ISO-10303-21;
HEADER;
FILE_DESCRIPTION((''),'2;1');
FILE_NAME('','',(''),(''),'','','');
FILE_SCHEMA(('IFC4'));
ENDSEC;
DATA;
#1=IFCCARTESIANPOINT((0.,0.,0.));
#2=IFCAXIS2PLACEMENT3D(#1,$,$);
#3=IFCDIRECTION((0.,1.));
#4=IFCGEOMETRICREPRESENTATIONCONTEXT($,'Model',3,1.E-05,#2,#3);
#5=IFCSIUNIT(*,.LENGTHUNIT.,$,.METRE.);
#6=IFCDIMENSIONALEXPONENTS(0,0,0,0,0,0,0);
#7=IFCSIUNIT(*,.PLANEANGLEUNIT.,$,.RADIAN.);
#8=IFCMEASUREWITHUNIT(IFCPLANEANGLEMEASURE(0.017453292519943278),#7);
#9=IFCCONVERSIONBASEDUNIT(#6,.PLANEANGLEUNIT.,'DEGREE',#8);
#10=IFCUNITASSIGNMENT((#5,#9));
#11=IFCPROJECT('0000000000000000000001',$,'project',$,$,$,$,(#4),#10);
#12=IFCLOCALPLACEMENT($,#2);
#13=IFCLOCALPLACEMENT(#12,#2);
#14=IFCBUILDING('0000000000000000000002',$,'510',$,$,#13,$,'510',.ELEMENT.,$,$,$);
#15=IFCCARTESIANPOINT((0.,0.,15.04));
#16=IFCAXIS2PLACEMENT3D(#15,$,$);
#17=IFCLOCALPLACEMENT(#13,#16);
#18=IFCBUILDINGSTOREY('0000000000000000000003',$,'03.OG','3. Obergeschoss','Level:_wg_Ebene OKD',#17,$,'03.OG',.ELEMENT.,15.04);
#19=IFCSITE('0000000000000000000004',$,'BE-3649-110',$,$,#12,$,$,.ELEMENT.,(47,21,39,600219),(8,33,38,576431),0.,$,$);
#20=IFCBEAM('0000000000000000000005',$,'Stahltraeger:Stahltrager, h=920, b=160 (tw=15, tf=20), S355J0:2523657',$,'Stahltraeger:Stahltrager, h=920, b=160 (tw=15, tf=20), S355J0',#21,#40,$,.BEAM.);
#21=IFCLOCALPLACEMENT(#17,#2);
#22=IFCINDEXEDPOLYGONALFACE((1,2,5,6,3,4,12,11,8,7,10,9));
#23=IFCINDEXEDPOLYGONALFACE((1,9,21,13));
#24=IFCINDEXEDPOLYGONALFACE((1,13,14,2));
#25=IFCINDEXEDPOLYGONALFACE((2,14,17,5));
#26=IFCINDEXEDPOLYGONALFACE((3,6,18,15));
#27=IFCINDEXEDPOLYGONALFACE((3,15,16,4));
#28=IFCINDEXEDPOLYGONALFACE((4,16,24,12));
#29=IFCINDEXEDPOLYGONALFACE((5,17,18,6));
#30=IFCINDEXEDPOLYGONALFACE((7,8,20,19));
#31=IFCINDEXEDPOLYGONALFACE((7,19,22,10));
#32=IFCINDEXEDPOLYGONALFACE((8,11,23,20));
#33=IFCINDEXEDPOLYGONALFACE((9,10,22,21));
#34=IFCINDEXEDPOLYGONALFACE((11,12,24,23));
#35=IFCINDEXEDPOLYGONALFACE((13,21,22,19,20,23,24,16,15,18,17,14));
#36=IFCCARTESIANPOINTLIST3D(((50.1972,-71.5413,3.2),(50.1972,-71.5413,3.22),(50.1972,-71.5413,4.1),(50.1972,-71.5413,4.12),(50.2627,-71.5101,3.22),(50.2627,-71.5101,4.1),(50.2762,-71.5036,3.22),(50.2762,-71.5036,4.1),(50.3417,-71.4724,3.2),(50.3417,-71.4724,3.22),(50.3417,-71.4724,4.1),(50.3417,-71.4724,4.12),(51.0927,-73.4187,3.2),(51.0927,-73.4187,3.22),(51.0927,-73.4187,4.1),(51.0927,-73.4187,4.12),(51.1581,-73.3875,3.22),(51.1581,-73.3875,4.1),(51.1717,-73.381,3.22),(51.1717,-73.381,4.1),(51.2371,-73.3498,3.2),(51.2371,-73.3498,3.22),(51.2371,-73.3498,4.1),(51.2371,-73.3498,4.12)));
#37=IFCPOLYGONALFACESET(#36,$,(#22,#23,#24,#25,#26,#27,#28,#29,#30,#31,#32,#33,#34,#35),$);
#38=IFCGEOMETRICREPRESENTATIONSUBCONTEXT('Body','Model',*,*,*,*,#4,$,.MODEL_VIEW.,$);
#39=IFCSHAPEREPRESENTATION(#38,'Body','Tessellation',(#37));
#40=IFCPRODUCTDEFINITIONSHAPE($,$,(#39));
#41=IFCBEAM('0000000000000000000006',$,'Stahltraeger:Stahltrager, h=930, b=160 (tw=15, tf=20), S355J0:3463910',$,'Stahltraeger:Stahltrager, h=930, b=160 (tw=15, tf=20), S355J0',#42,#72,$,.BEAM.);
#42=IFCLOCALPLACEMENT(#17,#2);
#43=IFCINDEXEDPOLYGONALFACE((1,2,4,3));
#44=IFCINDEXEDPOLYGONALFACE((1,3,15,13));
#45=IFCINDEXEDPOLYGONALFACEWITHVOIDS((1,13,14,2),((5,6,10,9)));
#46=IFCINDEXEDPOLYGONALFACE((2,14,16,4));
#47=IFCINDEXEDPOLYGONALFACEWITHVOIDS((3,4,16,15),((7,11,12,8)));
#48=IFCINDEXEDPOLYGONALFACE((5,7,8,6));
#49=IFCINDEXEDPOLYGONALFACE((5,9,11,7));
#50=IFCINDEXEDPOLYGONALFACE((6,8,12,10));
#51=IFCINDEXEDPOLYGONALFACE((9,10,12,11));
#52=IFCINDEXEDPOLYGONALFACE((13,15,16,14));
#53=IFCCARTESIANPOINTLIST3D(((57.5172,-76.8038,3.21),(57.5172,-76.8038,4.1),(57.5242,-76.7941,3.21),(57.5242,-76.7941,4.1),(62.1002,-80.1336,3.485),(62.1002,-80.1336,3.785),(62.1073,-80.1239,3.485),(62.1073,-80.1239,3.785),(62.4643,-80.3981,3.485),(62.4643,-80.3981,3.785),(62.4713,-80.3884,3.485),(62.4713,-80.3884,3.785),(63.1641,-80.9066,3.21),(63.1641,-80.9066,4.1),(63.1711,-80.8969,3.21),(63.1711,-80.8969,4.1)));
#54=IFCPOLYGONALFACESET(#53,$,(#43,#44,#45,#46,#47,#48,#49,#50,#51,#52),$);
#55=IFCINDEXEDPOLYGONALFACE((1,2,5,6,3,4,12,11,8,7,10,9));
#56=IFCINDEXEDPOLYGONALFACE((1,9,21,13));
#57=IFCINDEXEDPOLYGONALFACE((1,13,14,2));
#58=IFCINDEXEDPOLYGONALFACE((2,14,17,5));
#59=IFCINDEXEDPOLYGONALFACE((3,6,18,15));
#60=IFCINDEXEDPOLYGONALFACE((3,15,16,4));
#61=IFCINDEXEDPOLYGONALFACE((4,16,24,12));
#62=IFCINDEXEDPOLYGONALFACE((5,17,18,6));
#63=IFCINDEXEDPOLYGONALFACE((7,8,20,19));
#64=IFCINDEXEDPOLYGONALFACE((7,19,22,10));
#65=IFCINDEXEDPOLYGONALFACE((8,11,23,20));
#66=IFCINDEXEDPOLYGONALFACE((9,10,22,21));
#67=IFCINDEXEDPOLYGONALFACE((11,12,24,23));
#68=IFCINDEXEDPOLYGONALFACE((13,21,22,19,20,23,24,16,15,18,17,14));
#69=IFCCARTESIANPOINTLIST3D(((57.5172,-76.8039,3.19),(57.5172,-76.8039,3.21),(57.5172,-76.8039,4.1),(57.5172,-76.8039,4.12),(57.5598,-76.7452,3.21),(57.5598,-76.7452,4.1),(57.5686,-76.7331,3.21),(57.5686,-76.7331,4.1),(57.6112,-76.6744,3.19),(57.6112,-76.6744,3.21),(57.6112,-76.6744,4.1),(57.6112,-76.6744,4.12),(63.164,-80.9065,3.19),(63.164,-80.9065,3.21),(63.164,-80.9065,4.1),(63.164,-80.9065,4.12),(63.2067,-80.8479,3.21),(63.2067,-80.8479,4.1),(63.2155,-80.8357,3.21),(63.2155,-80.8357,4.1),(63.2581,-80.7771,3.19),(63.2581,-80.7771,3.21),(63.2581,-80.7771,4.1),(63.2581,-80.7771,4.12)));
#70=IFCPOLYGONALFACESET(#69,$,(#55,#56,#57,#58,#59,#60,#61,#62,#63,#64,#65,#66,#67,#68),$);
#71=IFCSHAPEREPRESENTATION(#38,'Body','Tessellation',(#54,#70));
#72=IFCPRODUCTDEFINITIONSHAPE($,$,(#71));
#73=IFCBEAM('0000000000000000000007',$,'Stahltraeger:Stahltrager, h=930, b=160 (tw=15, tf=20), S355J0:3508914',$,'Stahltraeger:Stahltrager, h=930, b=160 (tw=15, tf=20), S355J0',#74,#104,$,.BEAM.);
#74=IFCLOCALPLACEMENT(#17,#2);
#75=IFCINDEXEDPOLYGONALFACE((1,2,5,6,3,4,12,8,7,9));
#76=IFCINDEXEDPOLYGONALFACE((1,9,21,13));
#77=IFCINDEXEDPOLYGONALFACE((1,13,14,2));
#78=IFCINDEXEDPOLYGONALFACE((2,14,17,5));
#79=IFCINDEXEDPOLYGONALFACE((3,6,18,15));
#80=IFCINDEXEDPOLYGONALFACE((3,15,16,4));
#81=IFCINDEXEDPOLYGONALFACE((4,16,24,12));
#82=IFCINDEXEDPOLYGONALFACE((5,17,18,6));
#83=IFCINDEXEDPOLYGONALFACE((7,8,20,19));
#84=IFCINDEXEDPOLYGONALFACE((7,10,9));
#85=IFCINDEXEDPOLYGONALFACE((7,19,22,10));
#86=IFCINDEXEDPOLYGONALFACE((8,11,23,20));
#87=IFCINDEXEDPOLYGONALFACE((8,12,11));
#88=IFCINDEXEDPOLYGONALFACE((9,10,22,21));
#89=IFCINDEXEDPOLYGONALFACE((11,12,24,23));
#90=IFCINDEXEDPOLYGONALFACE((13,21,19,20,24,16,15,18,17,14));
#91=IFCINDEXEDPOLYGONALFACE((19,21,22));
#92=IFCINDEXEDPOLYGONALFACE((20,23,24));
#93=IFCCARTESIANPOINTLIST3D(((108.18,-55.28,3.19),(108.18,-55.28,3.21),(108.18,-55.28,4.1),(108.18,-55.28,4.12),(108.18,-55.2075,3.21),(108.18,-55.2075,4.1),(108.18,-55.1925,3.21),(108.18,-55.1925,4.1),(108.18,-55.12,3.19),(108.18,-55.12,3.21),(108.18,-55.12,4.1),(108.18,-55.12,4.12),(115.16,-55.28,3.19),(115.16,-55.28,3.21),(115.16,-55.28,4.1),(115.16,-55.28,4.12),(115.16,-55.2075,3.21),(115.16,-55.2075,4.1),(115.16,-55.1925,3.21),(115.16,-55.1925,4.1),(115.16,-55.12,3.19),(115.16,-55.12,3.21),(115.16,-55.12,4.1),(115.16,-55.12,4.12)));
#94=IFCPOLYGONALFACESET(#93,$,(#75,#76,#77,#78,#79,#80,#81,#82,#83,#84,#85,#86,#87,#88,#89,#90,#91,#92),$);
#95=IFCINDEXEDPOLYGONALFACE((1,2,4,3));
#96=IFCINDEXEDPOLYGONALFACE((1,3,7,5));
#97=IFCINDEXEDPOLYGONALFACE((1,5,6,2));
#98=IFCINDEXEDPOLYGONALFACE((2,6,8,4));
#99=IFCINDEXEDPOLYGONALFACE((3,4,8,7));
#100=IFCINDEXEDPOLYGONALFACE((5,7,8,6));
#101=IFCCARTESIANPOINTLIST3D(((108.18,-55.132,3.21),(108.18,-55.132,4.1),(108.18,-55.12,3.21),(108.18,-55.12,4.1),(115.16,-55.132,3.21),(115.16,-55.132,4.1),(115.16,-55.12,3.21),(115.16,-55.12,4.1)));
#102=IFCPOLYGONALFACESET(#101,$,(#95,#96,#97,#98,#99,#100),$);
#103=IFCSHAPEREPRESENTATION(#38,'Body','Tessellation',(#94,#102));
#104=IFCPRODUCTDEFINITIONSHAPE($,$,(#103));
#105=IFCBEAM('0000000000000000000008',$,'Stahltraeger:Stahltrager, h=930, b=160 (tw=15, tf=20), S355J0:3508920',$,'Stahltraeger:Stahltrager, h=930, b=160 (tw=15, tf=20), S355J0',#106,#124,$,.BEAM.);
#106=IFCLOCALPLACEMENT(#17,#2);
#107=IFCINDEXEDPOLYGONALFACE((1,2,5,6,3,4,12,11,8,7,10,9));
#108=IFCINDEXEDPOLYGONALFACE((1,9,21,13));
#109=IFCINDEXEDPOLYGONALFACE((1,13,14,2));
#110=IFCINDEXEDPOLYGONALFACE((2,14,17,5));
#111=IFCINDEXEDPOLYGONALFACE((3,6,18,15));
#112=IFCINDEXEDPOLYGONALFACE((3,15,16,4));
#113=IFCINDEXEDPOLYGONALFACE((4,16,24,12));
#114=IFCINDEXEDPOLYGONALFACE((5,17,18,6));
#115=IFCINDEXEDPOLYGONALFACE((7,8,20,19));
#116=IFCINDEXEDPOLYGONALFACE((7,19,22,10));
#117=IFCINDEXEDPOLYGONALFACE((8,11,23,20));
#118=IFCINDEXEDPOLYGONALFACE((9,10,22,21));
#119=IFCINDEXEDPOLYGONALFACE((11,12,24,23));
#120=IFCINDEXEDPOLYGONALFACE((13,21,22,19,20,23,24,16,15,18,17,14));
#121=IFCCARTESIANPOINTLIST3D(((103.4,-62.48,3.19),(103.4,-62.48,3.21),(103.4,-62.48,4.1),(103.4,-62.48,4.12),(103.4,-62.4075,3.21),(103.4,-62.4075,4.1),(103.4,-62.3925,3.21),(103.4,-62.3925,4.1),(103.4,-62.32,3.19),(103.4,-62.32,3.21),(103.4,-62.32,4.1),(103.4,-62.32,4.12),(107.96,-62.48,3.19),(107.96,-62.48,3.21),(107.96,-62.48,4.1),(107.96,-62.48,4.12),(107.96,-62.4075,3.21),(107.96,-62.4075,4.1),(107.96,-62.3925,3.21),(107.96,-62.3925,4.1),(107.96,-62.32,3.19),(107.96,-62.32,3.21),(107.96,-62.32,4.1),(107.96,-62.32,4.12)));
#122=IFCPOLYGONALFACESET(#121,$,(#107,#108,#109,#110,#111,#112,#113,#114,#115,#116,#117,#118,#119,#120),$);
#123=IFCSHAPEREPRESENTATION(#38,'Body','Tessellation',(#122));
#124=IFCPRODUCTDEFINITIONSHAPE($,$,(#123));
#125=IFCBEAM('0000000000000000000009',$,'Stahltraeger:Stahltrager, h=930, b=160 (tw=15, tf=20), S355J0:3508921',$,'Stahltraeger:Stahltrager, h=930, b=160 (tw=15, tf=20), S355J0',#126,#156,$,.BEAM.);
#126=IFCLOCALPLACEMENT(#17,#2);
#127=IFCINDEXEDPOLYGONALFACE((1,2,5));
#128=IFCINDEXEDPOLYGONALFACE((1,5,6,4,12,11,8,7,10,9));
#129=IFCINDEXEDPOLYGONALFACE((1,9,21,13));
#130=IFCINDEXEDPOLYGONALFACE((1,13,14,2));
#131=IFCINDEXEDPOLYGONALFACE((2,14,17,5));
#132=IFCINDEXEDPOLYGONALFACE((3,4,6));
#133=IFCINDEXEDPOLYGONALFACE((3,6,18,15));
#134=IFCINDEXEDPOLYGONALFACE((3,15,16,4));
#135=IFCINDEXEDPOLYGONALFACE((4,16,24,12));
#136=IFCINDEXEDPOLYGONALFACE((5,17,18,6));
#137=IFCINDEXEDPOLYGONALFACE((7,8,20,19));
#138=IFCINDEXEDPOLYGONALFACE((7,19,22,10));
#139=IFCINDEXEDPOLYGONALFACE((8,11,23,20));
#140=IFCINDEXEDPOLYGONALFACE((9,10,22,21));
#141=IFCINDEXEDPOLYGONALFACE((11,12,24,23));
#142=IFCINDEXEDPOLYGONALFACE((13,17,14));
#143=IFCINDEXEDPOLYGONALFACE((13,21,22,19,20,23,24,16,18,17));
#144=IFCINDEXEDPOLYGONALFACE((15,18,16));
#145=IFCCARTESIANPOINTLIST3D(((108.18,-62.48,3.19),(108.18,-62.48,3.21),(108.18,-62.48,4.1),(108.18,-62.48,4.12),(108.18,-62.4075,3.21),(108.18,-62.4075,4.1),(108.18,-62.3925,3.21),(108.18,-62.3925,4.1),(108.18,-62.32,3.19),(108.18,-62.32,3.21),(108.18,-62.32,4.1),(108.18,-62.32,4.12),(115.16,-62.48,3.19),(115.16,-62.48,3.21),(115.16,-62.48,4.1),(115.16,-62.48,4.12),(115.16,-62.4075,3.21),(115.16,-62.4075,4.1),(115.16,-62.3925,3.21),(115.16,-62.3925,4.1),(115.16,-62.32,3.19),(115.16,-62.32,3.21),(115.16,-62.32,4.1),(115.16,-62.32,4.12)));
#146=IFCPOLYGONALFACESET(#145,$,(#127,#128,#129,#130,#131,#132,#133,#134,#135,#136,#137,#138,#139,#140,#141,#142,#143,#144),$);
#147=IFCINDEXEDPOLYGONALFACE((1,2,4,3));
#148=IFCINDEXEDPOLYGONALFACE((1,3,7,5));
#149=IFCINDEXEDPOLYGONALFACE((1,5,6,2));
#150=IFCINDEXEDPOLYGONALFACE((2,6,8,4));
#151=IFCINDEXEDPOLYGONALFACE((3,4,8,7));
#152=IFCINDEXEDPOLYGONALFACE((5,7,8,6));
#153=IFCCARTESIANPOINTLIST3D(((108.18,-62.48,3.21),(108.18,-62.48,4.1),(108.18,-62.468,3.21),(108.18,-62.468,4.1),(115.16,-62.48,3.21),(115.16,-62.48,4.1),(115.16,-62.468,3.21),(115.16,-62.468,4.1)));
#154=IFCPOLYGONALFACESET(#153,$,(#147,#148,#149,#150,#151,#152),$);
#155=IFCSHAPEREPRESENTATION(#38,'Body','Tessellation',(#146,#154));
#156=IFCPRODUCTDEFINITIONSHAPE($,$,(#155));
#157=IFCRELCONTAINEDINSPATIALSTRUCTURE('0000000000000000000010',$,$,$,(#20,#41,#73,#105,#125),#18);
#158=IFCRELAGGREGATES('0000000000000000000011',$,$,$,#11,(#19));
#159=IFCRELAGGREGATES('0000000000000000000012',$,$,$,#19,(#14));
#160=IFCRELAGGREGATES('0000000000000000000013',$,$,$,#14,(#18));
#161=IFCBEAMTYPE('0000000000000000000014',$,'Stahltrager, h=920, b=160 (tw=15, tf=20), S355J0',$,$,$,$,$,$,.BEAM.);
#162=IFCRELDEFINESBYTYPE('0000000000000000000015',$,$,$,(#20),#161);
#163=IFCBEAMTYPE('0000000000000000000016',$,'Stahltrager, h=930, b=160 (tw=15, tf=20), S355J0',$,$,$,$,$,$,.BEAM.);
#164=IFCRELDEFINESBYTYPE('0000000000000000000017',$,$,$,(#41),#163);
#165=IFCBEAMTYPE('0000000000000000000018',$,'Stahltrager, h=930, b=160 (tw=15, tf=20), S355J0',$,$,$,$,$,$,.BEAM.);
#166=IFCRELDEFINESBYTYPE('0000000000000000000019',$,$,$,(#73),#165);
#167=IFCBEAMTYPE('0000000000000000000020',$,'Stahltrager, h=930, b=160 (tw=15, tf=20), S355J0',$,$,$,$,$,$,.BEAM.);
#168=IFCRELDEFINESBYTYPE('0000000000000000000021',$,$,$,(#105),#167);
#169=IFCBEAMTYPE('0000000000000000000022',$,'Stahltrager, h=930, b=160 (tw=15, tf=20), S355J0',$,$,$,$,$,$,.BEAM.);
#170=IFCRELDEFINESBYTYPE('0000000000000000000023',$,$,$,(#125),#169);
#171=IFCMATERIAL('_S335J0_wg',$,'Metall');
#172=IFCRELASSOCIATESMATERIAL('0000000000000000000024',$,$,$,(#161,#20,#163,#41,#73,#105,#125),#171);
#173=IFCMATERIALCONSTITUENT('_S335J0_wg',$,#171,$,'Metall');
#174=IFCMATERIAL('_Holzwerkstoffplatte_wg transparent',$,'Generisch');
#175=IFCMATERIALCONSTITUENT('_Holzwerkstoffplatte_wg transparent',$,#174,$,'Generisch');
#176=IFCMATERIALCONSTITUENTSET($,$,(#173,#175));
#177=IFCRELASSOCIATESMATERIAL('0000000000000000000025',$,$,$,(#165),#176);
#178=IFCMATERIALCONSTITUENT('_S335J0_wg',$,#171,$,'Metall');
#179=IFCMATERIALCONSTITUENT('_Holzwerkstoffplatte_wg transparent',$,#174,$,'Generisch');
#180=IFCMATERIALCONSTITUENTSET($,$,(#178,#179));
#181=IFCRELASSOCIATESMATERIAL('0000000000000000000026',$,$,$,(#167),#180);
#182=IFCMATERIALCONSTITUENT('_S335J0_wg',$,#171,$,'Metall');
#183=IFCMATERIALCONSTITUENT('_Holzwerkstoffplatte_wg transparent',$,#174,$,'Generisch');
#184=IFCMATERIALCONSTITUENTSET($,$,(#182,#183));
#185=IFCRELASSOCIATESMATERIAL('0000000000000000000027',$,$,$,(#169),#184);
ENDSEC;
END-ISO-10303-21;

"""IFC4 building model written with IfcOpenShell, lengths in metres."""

from ifc_helpers import new_model, entity, si_unit, converted_unit, direction, frame, origin, place, context, subcontext, project, spatial, indexed_curve, outline, extrude, source, transform, mapped, material, constituent, constituent_set, type_object, type_shapes, element, save


model = new_model("IFC4")

# Units and contexts
model_context = context("Model", 3, precision=1e-05, world=origin(), true_north=direction((0.0, 1.0)))
body_context = subcontext(model_context, "Body", "Model", "MODEL_VIEW")
ifc_project = project(units=[si_unit("LENGTHUNIT", "METRE"), converted_unit("PLANEANGLEUNIT", "DEGREE", entity("IfcPlaneAngleMeasure", 0.017453292519943278), si_unit("PLANEANGLEUNIT", "RADIAN"), dimensions=[0, 0, 0, 0, 0, 0, 0])], contexts=[model_context])

# Site, building, storey
site_placement = place(None, origin())
site = spatial("IfcSite", under=ifc_project, at=site_placement, Name="BE-3649-110", CompositionType="ELEMENT", RefLatitude=(47, 21, 39, 600219), RefLongitude=(8, 33, 38, 576431), RefElevation=0.0)
building_placement = place(site_placement, origin())
building = spatial("IfcBuilding", under=site, at=building_placement, Name="510", LongName="510", CompositionType="ELEMENT")
storey_placement = place(building_placement, frame((0.0, 0.0, 15.04)))
storey = spatial("IfcBuildingStorey", under=building, at=storey_placement, Name="03.OG", Description="3. Obergeschoss", ObjectType="Level:_wg_Ebene OKD", LongName="03.OG", CompositionType="ELEMENT", Elevation=15.04)

# Beams, openings
ifc_material_1 = material(Name="_S335J0_wg", Category="Metall")
beam_type_1 = type_object("IfcBeamType", Name="Stahltrager, h=920, b=160 (tw=15, tf=20), S355J0", PredefinedType="BEAM", material=ifc_material_1)
shared_shape_1 = source(origin(), body_context, "Body", "SweptSolid", [
    extrude(outline(indexed_curve([(-0.08, -0.44), (-0.08, -0.46), (0.08, -0.46), (0.08, -0.44), (0.0075, -0.44), (0.0075, 0.44), (0.08, 0.44), (0.08, 0.46), (-0.08, 0.46), (-0.08, 0.44), (-0.0075, 0.44), (-0.0075, -0.44), (-0.08, -0.44)], self_intersect=False)), frame((0.9677, 0.0344, 0.46), z_axis=(0.430511, -0.902585, 0.0), x_axis=(0.902585, 0.430511, 0.0)), (0.0, 0.0, -1.0), 2.08),
])
type_shapes(beam_type_1, [shared_shape_1])
beam_1_placement = place(storey_placement, frame((50.1972, -73.4187, 3.2)))
beam_1 = element("IfcBeam", 1, at=beam_1_placement, inside=storey, type_object=beam_type_1, material=ifc_material_1, Name="Stahltraeger:Stahltrager, h=920, b=160 (tw=15, tf=20), S355J0:2523657", ObjectType="Stahltraeger:Stahltrager, h=920, b=160 (tw=15, tf=20), S355J0", PredefinedType="BEAM", context=body_context, shape_type="MappedRepresentation", body=[
    mapped(shared_shape_1, transform((0.0, 0.0, 0.0), scale=1.0)),
])
opening_1_placement = place(storey_placement, frame((50.1972, -73.4187, 3.2)))
element("IfcOpeningElement", 2, at=opening_1_placement, cuts=beam_1, PredefinedType="OPENING", context=body_context, shape_type="SweptSolid", body=[
    extrude(outline(indexed_curve([(-0.32, -0.22), (0.32, -0.22), (0.32, 0.22), (-0.32, 0.22), (-0.32, -0.22)], self_intersect=False)), frame((0.5148, 0.9664, -14.6217), z_axis=(0.902585, 0.430511, 0.0), x_axis=(-0.430511, 0.902585, 0.0)), (0.0, 0.0, 1.0), 0.015),
])
beam_type_2 = type_object("IfcBeamType", Name="Stahltrager, h=930, b=160 (tw=15, tf=20), S355J0", PredefinedType="BEAM", material=ifc_material_1)
shared_shape_2 = source(origin(), body_context, "Body", "SweptSolid", [
    extrude(outline(indexed_curve([(-0.445, -3.49), (0.445, -3.49), (0.445, 3.49), (-0.445, 3.49), (-0.445, -3.49)], self_intersect=False), holes=[indexed_curve([(-0.13, -2.175), (0.17, -2.175), (0.17, -2.625), (-0.13, -2.625), (-0.13, -2.175)], self_intersect=False)]), frame((2.8235, 2.0514, 0.465), z_axis=(0.587785, 0.809017, 0.0), x_axis=(0.0, 0.0, -1.0)), (0.0, 0.0, 1.0), 0.012),
    extrude(outline(indexed_curve([(-0.08, -0.445), (-0.08, -0.465), (0.08, -0.465), (0.08, -0.445), (0.0075, -0.445), (0.0075, 0.445), (0.08, 0.445), (0.08, 0.465), (-0.08, 0.465), (-0.08, 0.445), (-0.0075, 0.445), (-0.0075, -0.445), (-0.08, -0.445)], self_intersect=False)), frame((0.0471, 4.1674, 0.465), z_axis=(-0.809017, 0.587785, 0.0), x_axis=(-0.587785, -0.809017, 0.0)), (0.0, 0.0, -1.0), 6.9799),
])
type_shapes(beam_type_2, [shared_shape_2])
beam_2_placement = place(storey_placement, frame((57.5172, -80.9066, 3.19)))
beam_2 = element("IfcBeam", 3, at=beam_2_placement, inside=storey, type_object=beam_type_2, material=ifc_material_1, Name="Stahltraeger:Stahltrager, h=930, b=160 (tw=15, tf=20), S355J0:3463910", ObjectType="Stahltraeger:Stahltrager, h=930, b=160 (tw=15, tf=20), S355J0", PredefinedType="BEAM", context=body_context, shape_type="MappedRepresentation", body=[
    mapped(shared_shape_2, transform((0.0, 0.0, 0.0), scale=1.0)),
])
opening_2_placement = place(storey_placement, frame((57.5172, -80.9066, 3.19)))
element("IfcOpeningElement", 4, at=opening_2_placement, cuts=beam_2, PredefinedType="OPENING", context=body_context, shape_type="SweptSolid", body=[
    extrude(outline(indexed_curve([(-0.225, -0.15), (0.225, -0.15), (0.225, 0.15), (-0.225, 0.15), (-0.225, -0.15)], self_intersect=False)), frame((4.8165, 0.7115, -14.595), z_axis=(-0.587785, -0.809017, 0.0), x_axis=(-0.809017, 0.587785, 0.0)), (0.0, 0.0, 1.0), 0.015),
])

# Beams
ifc_constituent_1 = constituent(ifc_material_1, Name="_S335J0_wg", Category="Metall")
ifc_material_2 = material(Name="_Holzwerkstoffplatte_wg transparent", Category="Generisch")
ifc_constituent_2 = constituent(ifc_material_2, Name="_Holzwerkstoffplatte_wg transparent", Category="Generisch")
ifc_constituent_set_1 = constituent_set(constituents=[ifc_constituent_1, ifc_constituent_2])
beam_type_3 = type_object("IfcBeamType", Name="Stahltrager, h=930, b=160 (tw=15, tf=20), S355J0", PredefinedType="BEAM", material=ifc_constituent_set_1)
shared_shape_3 = source(origin(), body_context, "Body", "SweptSolid", [
    extrude(outline(indexed_curve([(-0.465, -0.08), (-0.445, -0.08), (-0.445, -0.0075), (0.445, -0.0075), (0.445, -0.08), (0.465, -0.08), (0.465, 0.08), (0.445, 0.08), (0.445, 0.0075), (-0.445, 0.0075), (-0.445, 0.08), (-0.465, 0.08), (-0.465, -0.08)], self_intersect=False)), frame((-3.49, 0.0, 0.0), z_axis=(1.0, 0.0, 0.0), x_axis=(0.0, 0.0, -1.0)), (0.0, 0.0, 1.0), 6.98),
    extrude(outline(indexed_curve([(-0.445, -0.006), (0.445, -0.006), (0.445, 0.006), (-0.445, 0.006), (-0.445, -0.006)], self_intersect=False)), frame((-3.49, 0.074, 0.0), z_axis=(1.0, 0.0, 0.0), x_axis=(0.0, 0.0, -1.0)), (0.0, 0.0, 1.0), 6.98),
])
type_shapes(beam_type_3, [shared_shape_3])
beam_3_placement = place(storey_placement, frame((111.67, -55.2, 3.655)))
element("IfcBeam", 5, at=beam_3_placement, inside=storey, type_object=beam_type_3, material=ifc_material_1, Name="Stahltraeger:Stahltrager, h=930, b=160 (tw=15, tf=20), S355J0:3508914", ObjectType="Stahltraeger:Stahltrager, h=930, b=160 (tw=15, tf=20), S355J0", PredefinedType="BEAM", context=body_context, shape_type="MappedRepresentation", body=[
    mapped(shared_shape_3, transform((0.0, 0.0, 0.0), scale=1.0)),
])
ifc_constituent_3 = constituent(ifc_material_1, Name="_S335J0_wg", Category="Metall")
ifc_constituent_4 = constituent(ifc_material_2, Name="_Holzwerkstoffplatte_wg transparent", Category="Generisch")
ifc_constituent_set_2 = constituent_set(constituents=[ifc_constituent_3, ifc_constituent_4])
beam_type_4 = type_object("IfcBeamType", Name="Stahltrager, h=930, b=160 (tw=15, tf=20), S355J0", PredefinedType="BEAM", material=ifc_constituent_set_2)
shared_shape_4 = source(origin(), body_context, "Body", "SweptSolid", [
    extrude(outline(indexed_curve([(-0.465, -0.08), (-0.445, -0.08), (-0.445, -0.0075), (0.445, -0.0075), (0.445, -0.08), (0.465, -0.08), (0.465, 0.08), (0.445, 0.08), (0.445, 0.0075), (-0.445, 0.0075), (-0.445, 0.08), (-0.465, 0.08), (-0.465, -0.08)], self_intersect=False)), frame((-2.28, 0.0, 0.0), z_axis=(1.0, 0.0, 0.0), x_axis=(0.0, 0.0, -1.0)), (0.0, 0.0, 1.0), 4.56),
])
type_shapes(beam_type_4, [shared_shape_4])
beam_4_placement = place(storey_placement, frame((105.68, -62.4, 3.655)))
element("IfcBeam", 6, at=beam_4_placement, inside=storey, type_object=beam_type_4, material=ifc_material_1, Name="Stahltraeger:Stahltrager, h=930, b=160 (tw=15, tf=20), S355J0:3508920", ObjectType="Stahltraeger:Stahltrager, h=930, b=160 (tw=15, tf=20), S355J0", PredefinedType="BEAM", context=body_context, shape_type="MappedRepresentation", body=[
    mapped(shared_shape_4, transform((0.0, 0.0, 0.0), scale=1.0)),
])
ifc_constituent_5 = constituent(ifc_material_1, Name="_S335J0_wg", Category="Metall")
ifc_constituent_6 = constituent(ifc_material_2, Name="_Holzwerkstoffplatte_wg transparent", Category="Generisch")
ifc_constituent_set_3 = constituent_set(constituents=[ifc_constituent_5, ifc_constituent_6])
beam_type_5 = type_object("IfcBeamType", Name="Stahltrager, h=930, b=160 (tw=15, tf=20), S355J0", PredefinedType="BEAM", material=ifc_constituent_set_3)
shared_shape_5 = source(origin(), body_context, "Body", "SweptSolid", [
    extrude(outline(indexed_curve([(-0.465, -0.08), (-0.445, -0.08), (-0.445, -0.0075), (0.445, -0.0075), (0.445, -0.08), (0.465, -0.08), (0.465, 0.08), (0.445, 0.08), (0.445, 0.0075), (-0.445, 0.0075), (-0.445, 0.08), (-0.465, 0.08), (-0.465, -0.08)], self_intersect=False)), frame((-3.49, 0.0, 0.0), z_axis=(1.0, 0.0, 0.0), x_axis=(0.0, 0.0, -1.0)), (0.0, 0.0, 1.0), 6.98),
    extrude(outline(indexed_curve([(-0.445, -0.006), (0.445, -0.006), (0.445, 0.006), (-0.445, 0.006), (-0.445, -0.006)], self_intersect=False)), frame((-3.49, -0.074, 0.0), z_axis=(1.0, 0.0, 0.0), x_axis=(0.0, 0.0, -1.0)), (0.0, 0.0, 1.0), 6.98),
])
type_shapes(beam_type_5, [shared_shape_5])
beam_5_placement = place(storey_placement, frame((111.67, -62.4, 3.655)))
element("IfcBeam", 7, at=beam_5_placement, inside=storey, type_object=beam_type_5, material=ifc_material_1, Name="Stahltraeger:Stahltrager, h=930, b=160 (tw=15, tf=20), S355J0:3508921", ObjectType="Stahltraeger:Stahltrager, h=930, b=160 (tw=15, tf=20), S355J0", PredefinedType="BEAM", context=body_context, shape_type="MappedRepresentation", body=[
    mapped(shared_shape_5, transform((0.0, 0.0, 0.0), scale=1.0)),
])

save(model, "model.ifc")
